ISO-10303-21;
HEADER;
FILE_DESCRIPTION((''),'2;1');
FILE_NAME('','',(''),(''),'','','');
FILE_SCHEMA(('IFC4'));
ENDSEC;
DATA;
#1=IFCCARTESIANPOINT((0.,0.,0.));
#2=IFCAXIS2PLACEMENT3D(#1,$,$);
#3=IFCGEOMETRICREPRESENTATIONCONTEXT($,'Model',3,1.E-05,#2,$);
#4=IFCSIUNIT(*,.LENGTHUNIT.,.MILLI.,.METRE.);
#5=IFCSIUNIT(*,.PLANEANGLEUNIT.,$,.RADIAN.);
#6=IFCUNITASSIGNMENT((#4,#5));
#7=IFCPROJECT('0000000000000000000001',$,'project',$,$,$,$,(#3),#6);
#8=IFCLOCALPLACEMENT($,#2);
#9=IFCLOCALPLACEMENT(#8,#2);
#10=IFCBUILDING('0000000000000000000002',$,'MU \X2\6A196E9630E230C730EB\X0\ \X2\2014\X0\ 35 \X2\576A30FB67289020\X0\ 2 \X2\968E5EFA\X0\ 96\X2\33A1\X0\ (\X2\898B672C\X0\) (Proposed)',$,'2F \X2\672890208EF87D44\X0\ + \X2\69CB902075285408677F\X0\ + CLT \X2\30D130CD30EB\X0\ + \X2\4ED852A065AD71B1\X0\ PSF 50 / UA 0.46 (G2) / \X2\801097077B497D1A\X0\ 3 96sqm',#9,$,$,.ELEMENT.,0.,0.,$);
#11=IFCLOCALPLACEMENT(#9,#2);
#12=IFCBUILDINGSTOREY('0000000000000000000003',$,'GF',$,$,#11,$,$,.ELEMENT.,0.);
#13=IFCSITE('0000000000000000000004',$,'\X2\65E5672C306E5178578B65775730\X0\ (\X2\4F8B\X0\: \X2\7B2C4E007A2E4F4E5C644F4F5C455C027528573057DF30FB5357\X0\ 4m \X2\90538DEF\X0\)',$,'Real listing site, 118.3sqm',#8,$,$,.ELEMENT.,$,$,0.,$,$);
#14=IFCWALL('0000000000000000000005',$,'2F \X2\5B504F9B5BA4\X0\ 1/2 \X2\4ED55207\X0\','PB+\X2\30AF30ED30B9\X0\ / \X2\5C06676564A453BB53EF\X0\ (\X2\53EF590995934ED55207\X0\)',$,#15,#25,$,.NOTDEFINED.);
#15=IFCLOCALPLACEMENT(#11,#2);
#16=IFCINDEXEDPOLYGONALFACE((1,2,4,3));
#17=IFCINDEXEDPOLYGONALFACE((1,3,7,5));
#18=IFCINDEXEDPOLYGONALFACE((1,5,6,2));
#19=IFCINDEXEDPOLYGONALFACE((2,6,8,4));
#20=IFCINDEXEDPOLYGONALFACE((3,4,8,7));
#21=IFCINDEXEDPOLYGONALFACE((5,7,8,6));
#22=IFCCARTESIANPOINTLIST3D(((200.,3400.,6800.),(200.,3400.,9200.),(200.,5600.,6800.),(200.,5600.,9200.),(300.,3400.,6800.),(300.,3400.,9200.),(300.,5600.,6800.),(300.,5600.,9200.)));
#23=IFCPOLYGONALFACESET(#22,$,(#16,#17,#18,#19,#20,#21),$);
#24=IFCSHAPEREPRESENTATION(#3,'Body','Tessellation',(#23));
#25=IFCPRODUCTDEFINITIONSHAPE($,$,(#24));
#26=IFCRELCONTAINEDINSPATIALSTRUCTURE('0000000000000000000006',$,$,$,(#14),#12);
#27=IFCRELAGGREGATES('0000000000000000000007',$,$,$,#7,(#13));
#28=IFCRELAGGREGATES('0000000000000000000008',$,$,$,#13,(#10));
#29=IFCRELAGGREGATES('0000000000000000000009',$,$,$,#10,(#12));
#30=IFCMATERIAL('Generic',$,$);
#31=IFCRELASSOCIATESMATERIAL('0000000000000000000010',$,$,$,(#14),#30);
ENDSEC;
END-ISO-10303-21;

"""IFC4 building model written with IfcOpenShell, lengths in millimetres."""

from ifc_helpers import new_model, si_unit, frame, frame_2d, origin, place, context, project, spatial, rectangle, extrude, material, element, save


model = new_model("IFC4")

# Units and contexts
model_context = context("Model", 3, precision=1e-05, world=origin())
ifc_project = project(units=[si_unit("LENGTHUNIT", "METRE", prefix="MILLI"), si_unit("PLANEANGLEUNIT", "RADIAN")], contexts=[model_context])

# Site, building, storey
site_placement = place(None, origin())
site = spatial("IfcSite", under=ifc_project, at=site_placement, Name="日本の典型敷地 (例: 第一種低層住居専用地域・南 4m 道路)", ObjectType="Real listing site, 118.3sqm", CompositionType="ELEMENT", RefElevation=0.0)
building_placement = place(site_placement, origin())
building = spatial("IfcBuilding", under=site, at=building_placement, Name="MU 標準モデル — 35 坪・木造 2 階建 96㎡ (見本) (Proposed)", ObjectType="2F 木造軸組 + 構造用合板 + CLT パネル + 付加断熱 PSF 50 / UA 0.46 (G2) / 耐震等級 3 96sqm", CompositionType="ELEMENT", ElevationOfRefHeight=0.0, ElevationOfTerrain=0.0)
storey_placement = place(building_placement, origin())
storey = spatial("IfcBuildingStorey", under=building, at=storey_placement, Name="GF", CompositionType="ELEMENT", Elevation=0.0)

# Shared definitions
ifc_material_1 = material(Name="Generic")

# Wall
wall_1_placement = place(storey_placement, frame((100.0, 1700.0, 3400.0)))
element("IfcWall", 1, at=wall_1_placement, inside=storey, material=ifc_material_1, Name="2F 子供室 1/2 仕切", Description="PB+クロス / 将来撤去可 (可変間仕切)", PredefinedType="NOTDEFINED", context=model_context, shape_type="SweptSolid", body=[
    extrude(rectangle(XDim=100.0, YDim=2200.0, at=frame_2d((50.0, 1100.0))), frame((100.0, 1700.0, 3400.0)), (0.0, 0.0, 1.0), 2400.0),
])

save(model, "model.ifc")
